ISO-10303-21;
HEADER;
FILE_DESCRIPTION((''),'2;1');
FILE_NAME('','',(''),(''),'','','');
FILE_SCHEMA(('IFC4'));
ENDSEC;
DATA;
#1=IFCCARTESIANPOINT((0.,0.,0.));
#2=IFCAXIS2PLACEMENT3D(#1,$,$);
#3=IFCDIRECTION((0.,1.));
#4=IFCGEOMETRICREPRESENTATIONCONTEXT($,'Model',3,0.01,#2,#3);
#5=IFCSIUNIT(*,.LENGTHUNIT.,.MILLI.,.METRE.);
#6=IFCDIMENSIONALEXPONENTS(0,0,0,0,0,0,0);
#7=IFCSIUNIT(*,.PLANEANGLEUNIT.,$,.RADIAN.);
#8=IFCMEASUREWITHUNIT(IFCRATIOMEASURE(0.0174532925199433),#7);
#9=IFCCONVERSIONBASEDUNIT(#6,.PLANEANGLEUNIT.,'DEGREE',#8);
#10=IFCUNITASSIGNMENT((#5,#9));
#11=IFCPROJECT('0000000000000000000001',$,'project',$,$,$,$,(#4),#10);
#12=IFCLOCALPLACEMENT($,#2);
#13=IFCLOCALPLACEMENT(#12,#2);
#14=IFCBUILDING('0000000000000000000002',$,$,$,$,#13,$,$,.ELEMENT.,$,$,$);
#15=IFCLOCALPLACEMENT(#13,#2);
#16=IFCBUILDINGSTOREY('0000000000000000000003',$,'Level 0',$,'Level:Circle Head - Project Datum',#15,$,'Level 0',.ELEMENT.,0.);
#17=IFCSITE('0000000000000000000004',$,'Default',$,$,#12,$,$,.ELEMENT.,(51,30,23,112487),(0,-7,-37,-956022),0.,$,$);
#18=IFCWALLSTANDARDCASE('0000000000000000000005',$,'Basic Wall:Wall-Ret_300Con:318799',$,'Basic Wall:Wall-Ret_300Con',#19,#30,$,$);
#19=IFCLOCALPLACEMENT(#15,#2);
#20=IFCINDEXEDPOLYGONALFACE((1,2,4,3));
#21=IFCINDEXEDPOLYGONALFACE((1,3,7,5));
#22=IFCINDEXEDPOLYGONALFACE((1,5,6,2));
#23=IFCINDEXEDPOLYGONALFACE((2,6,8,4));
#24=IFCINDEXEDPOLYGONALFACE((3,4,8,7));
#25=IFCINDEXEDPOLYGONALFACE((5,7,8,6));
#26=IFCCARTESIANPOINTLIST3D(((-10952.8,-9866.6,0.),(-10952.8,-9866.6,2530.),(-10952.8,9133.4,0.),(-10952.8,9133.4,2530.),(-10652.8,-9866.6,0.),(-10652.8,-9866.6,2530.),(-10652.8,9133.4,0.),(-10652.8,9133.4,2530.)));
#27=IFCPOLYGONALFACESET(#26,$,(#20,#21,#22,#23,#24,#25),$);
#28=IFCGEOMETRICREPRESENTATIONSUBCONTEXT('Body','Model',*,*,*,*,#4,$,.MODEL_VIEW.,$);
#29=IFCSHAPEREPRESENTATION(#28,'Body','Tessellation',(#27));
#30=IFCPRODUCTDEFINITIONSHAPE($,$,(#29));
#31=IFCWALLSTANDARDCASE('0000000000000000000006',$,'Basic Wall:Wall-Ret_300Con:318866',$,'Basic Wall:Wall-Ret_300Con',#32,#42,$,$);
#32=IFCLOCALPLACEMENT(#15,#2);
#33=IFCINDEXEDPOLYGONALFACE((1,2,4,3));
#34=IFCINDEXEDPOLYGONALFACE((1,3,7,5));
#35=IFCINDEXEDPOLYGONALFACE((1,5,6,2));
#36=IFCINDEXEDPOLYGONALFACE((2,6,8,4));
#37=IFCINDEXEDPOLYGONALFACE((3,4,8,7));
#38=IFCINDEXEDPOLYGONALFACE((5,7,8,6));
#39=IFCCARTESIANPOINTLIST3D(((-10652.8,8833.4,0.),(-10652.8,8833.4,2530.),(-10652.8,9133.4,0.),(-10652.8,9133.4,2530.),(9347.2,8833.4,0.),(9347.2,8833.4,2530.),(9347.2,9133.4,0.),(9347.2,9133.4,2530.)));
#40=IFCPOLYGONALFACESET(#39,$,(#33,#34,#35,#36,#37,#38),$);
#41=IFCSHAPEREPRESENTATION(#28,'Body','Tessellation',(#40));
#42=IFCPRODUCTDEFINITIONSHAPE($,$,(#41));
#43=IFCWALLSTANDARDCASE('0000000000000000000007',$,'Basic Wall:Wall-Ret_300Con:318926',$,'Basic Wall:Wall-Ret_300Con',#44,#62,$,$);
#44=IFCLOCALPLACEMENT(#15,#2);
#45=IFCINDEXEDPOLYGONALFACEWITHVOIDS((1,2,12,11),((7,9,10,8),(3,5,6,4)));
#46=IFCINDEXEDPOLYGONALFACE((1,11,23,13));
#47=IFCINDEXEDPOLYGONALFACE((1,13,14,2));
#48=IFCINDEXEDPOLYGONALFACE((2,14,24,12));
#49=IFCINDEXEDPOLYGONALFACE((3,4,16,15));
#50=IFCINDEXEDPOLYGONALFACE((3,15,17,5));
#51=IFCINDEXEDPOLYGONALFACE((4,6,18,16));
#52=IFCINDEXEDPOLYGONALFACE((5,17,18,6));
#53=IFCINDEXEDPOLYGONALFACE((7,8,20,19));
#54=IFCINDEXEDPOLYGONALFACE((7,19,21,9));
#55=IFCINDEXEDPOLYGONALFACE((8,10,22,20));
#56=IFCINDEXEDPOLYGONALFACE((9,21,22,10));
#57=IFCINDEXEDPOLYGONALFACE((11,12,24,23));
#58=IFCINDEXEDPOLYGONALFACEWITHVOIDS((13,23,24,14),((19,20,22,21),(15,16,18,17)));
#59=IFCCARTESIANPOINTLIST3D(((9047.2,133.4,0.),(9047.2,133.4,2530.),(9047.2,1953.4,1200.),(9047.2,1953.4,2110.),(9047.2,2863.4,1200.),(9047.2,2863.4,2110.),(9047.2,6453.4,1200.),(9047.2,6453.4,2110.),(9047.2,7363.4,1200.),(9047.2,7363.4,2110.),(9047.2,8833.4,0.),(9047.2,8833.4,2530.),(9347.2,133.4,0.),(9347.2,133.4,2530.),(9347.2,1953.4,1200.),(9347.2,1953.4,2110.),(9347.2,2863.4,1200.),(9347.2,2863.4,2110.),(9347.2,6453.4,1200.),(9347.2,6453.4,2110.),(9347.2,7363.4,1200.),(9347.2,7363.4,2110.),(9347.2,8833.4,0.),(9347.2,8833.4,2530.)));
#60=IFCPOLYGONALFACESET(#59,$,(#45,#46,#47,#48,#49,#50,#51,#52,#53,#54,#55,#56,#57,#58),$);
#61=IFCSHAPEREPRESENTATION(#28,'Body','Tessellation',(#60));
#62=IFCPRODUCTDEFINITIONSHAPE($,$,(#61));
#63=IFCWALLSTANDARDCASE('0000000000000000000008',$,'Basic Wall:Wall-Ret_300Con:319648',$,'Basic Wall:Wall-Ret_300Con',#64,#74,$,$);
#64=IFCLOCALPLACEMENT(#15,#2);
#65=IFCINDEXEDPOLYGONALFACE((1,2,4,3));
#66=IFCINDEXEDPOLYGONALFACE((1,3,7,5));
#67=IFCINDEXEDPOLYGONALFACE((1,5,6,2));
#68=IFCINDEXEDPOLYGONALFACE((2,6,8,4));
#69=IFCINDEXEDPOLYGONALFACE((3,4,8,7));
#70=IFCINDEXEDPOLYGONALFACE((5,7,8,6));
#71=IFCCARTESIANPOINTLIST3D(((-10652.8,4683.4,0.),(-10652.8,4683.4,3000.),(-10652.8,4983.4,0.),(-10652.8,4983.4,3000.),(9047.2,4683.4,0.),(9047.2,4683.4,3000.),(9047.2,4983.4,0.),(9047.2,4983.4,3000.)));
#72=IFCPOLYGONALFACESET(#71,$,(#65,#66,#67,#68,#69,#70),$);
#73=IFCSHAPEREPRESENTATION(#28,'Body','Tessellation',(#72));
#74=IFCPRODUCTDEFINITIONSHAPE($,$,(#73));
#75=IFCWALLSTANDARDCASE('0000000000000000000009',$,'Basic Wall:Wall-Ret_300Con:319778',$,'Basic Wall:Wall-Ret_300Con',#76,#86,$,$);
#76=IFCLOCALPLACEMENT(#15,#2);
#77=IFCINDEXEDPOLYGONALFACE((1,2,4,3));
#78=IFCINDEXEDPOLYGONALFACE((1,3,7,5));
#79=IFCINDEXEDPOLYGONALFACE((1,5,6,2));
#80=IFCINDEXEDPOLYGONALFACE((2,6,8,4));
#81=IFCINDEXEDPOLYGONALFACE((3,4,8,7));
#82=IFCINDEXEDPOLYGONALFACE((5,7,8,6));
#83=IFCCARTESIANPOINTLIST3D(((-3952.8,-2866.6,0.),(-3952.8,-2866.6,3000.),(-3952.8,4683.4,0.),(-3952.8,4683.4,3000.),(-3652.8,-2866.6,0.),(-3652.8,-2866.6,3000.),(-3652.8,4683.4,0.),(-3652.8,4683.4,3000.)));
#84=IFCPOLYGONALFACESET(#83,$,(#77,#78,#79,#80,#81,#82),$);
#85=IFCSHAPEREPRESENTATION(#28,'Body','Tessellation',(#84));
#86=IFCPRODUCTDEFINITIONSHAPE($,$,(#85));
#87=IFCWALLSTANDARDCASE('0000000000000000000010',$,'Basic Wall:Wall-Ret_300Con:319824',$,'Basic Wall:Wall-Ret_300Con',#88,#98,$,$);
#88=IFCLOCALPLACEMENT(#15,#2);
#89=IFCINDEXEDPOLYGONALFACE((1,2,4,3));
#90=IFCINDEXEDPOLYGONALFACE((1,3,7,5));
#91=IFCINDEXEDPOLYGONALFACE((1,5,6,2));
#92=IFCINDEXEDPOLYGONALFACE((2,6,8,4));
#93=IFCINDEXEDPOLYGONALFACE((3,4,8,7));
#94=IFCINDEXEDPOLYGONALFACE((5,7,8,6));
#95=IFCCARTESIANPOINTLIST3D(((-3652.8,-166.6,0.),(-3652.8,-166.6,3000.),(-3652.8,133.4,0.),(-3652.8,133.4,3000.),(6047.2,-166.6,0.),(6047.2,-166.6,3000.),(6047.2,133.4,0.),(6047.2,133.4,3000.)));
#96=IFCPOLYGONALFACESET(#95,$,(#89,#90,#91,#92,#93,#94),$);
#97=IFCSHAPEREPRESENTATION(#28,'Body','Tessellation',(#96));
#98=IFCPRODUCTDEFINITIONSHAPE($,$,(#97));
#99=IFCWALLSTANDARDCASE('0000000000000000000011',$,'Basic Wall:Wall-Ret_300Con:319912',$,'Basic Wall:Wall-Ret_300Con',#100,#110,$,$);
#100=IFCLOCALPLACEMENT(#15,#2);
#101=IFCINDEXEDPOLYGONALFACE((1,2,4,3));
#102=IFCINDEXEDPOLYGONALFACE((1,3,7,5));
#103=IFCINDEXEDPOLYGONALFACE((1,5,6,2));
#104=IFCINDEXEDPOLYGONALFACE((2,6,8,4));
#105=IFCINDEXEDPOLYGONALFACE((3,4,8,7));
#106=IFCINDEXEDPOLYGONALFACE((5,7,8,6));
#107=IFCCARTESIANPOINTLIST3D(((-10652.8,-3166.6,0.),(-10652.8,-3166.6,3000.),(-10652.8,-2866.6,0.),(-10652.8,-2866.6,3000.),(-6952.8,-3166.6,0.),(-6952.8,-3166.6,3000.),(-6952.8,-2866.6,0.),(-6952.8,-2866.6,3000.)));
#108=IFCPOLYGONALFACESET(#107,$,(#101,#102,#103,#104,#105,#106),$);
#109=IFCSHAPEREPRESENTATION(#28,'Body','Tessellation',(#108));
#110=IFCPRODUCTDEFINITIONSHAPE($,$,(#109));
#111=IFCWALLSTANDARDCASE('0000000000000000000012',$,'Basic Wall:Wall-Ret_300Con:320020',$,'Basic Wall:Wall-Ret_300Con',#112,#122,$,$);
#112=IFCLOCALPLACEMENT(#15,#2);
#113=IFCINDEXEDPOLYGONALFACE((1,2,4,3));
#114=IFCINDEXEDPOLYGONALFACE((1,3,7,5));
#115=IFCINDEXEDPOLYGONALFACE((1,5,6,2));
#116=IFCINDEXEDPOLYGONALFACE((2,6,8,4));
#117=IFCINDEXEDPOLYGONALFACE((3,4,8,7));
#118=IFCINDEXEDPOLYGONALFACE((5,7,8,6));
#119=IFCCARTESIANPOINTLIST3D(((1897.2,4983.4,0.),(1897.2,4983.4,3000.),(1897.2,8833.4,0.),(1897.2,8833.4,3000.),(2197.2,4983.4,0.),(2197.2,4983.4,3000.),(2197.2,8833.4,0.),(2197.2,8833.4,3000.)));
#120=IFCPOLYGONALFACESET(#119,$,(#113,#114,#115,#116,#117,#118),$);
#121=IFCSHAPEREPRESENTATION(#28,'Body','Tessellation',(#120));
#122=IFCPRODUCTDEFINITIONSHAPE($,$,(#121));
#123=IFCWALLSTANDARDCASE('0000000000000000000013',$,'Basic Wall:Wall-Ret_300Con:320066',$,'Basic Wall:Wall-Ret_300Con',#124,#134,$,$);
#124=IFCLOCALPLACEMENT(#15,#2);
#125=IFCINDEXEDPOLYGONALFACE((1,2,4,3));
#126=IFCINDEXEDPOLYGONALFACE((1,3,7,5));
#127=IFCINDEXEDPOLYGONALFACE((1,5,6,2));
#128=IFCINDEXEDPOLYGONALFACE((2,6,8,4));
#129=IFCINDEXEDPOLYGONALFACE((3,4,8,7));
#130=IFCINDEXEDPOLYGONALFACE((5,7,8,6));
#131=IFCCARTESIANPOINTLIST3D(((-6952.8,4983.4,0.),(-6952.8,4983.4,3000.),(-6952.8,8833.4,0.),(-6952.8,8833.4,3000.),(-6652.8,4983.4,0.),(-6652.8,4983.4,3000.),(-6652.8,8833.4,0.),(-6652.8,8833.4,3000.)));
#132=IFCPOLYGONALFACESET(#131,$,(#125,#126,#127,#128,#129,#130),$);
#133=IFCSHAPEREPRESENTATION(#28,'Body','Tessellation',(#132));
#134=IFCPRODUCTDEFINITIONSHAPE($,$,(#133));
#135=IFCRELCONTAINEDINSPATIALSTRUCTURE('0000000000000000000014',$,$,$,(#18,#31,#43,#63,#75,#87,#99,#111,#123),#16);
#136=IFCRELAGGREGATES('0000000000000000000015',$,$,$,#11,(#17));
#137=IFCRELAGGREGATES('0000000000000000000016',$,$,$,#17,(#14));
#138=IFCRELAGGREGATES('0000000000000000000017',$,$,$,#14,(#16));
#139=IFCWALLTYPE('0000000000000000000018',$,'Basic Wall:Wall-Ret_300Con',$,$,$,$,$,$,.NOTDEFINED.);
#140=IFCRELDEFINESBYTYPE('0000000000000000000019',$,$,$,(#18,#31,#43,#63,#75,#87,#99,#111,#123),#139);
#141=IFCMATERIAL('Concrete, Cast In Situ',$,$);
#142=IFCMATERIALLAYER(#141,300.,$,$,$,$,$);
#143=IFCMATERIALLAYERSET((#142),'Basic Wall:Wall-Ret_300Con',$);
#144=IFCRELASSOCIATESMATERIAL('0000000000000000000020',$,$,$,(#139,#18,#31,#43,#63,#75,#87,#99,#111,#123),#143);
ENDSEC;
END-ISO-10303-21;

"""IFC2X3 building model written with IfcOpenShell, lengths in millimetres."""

from ifc_helpers import new_model, entity, si_unit, converted_unit, direction, frame, frame_2d, origin, place, context, subcontext, project, spatial, polyline, rectangle, extrude, clip, bounded_halfspace, material, layer, layer_set, layer_usage, type_object, element, save


model = new_model("IFC2X3")

# Units and contexts
model_context = context("Model", 3, precision=0.01, world=origin(), true_north=direction((0.0, 1.0)))
body_context = subcontext(model_context, "Body", "Model", "MODEL_VIEW")
ifc_project = project(units=[si_unit("LENGTHUNIT", "METRE", prefix="MILLI"), converted_unit("PLANEANGLEUNIT", "DEGREE", entity("IfcRatioMeasure", 0.0174532925199433), si_unit("PLANEANGLEUNIT", "RADIAN"), dimensions=[0, 0, 0, 0, 0, 0, 0])], contexts=[model_context])

# Site, building, storey
site_placement = place(None, origin())
site = spatial("IfcSite", under=ifc_project, at=site_placement, Name="Default", CompositionType="ELEMENT", RefLatitude=(51, 30, 23, 112487), RefLongitude=(0, -7, -37, -956022), RefElevation=0.0)
building_placement = place(site_placement, origin())
building = spatial("IfcBuilding", under=site, at=building_placement, CompositionType="ELEMENT")
storey_placement = place(building_placement, origin())
storey = spatial("IfcBuildingStorey", under=building, at=storey_placement, Name="Level 0", ObjectType="Level:Circle Head - Project Datum", LongName="Level 0", CompositionType="ELEMENT", Elevation=0.0)

# Shared definitions
ifc_material_1 = material(Name="Concrete, Cast In Situ")
ifc_layer_1 = layer(ifc_material_1, 300.0)
ifc_layer_set_1 = layer_set([ifc_layer_1], Name="Basic Wall:Wall-Ret_300Con")
wall_type = type_object("IfcWallType", Name="Basic Wall:Wall-Ret_300Con", PredefinedType="NOTDEFINED", material=ifc_layer_set_1)

# Walls
ifc_layer_usage_1 = layer_usage(ifc_layer_set_1, "AXIS2", "NEGATIVE", 150.0)
wall_1_placement = place(storey_placement, frame((-10802.8, -9866.6, 0.0), z_axis=(0.0, 0.0, 1.0), x_axis=(0.0, 1.0, 0.0)))
element("IfcWallStandardCase", 1, at=wall_1_placement, inside=storey, type_object=wall_type, material=ifc_layer_usage_1, Name="Basic Wall:Wall-Ret_300Con:318799", ObjectType="Basic Wall:Wall-Ret_300Con", context=body_context, shape_type="Clipping", body=[
    clip(extrude(rectangle(XDim=19000.0, YDim=300.0, at=frame_2d((9500.0, 0.0), x_axis=(-1.0, 0.0))), origin(), (0.0, 0.0, 1.0), 2530.0), bounded_halfspace(frame((0.0, -150.0, 2530.0), z_axis=(0.0, 0.0, -1.0), x_axis=(0.0, -1.0, 0.0)), True, frame((0.0, -150.0, 2530.0)), polyline([(0.0, 0.0), (18700.0, 0.0), (19000.0, 0.0), (19000.0, 300.0), (0.0, 300.0), (0.0, 0.0)]))),
])
ifc_layer_usage_2 = layer_usage(ifc_layer_set_1, "AXIS2", "NEGATIVE", 150.0)
wall_2_placement = place(storey_placement, frame((-10652.8, 8983.4, 0.0)))
element("IfcWallStandardCase", 2, at=wall_2_placement, inside=storey, type_object=wall_type, material=ifc_layer_usage_2, Name="Basic Wall:Wall-Ret_300Con:318866", ObjectType="Basic Wall:Wall-Ret_300Con", context=body_context, shape_type="Clipping", body=[
    clip(extrude(rectangle(XDim=20000.0, YDim=300.0, at=frame_2d((10000.0, 0.0), x_axis=(-1.0, 0.0))), origin(), (0.0, 0.0, 1.0), 2530.0), bounded_halfspace(frame((0.0, -150.0, 2530.0), z_axis=(0.0, 0.0, -1.0), x_axis=(1.0, 0.0, 0.0)), True, frame((0.0, -150.0, 2530.0)), polyline([(0.0, 0.0), (19700.0, 0.0), (20000.0, 0.0), (20000.0, 300.0), (0.0, 300.0), (0.0, 0.0)]))),
])

# Wall, openings
ifc_layer_usage_3 = layer_usage(ifc_layer_set_1, "AXIS2", "NEGATIVE", 150.0)
wall_3_placement = place(storey_placement, frame((9197.2, 8833.4, 0.0), z_axis=(0.0, 0.0, 1.0), x_axis=(0.0, -1.0, 0.0)))
wall_3 = element("IfcWallStandardCase", 3, at=wall_3_placement, inside=storey, type_object=wall_type, material=ifc_layer_usage_3, Name="Basic Wall:Wall-Ret_300Con:318926", ObjectType="Basic Wall:Wall-Ret_300Con", context=body_context, shape_type="Clipping", body=[
    clip(extrude(rectangle(XDim=8700.0, YDim=300.0, at=frame_2d((4350.0, 0.0), x_axis=(-1.0, 0.0))), origin(), (0.0, 0.0, 1.0), 2530.0), bounded_halfspace(frame((0.0, -150.0, 2530.0), z_axis=(0.0, 0.0, -1.0), x_axis=(0.0, 1.0, 0.0)), True, frame((0.0, -150.0, 2530.0)), polyline([(0.0, 0.0), (8700.0, 0.0), (8700.0, 300.0), (0.0, 300.0), (0.0, 0.0)]))),
])
opening_1_placement = place(wall_3_placement, frame((5970.0, -150.0, 1200.0)))
element("IfcOpeningElement", 4, at=opening_1_placement, cuts=wall_3, ObjectType="Opening", context=body_context, shape_type="SweptSolid", body=[
    extrude(rectangle(XDim=910.0, YDim=910.0, at=frame_2d((455.0, 455.0), x_axis=(-1.0, 0.0))), frame((0.0, 0.0, 0.0), z_axis=(0.0, 1.0, 0.0), x_axis=(0.0, 0.0, 1.0)), (0.0, 0.0, 1.0), 300.0),
])
opening_2_placement = place(wall_3_placement, frame((1470.0, -150.0, 1200.0)))
element("IfcOpeningElement", 5, at=opening_2_placement, cuts=wall_3, ObjectType="Opening", context=body_context, shape_type="SweptSolid", body=[
    extrude(rectangle(XDim=910.0, YDim=910.0, at=frame_2d((455.0, 455.0), x_axis=(-1.0, 0.0))), frame((0.0, 0.0, 0.0), z_axis=(0.0, 1.0, 0.0), x_axis=(0.0, 0.0, 1.0)), (0.0, 0.0, 1.0), 300.0),
])

# Walls
ifc_layer_usage_4 = layer_usage(ifc_layer_set_1, "AXIS2", "NEGATIVE", 150.0)
wall_4_placement = place(storey_placement, frame((-10652.8, 4833.4, 0.0)))
element("IfcWallStandardCase", 6, at=wall_4_placement, inside=storey, type_object=wall_type, material=ifc_layer_usage_4, Name="Basic Wall:Wall-Ret_300Con:319648", ObjectType="Basic Wall:Wall-Ret_300Con", context=body_context, shape_type="SweptSolid", body=[
    extrude(rectangle(XDim=19700.0, YDim=300.0, at=frame_2d((9850.0, 0.0), x_axis=(-1.0, 0.0))), origin(), (0.0, 0.0, 1.0), 3000.0),
])
ifc_layer_usage_5 = layer_usage(ifc_layer_set_1, "AXIS2", "NEGATIVE", 150.0)
wall_5_placement = place(storey_placement, frame((-3802.8, 4683.4, 0.0), z_axis=(0.0, 0.0, 1.0), x_axis=(0.0, -1.0, 0.0)))
element("IfcWallStandardCase", 7, at=wall_5_placement, inside=storey, type_object=wall_type, material=ifc_layer_usage_5, Name="Basic Wall:Wall-Ret_300Con:319778", ObjectType="Basic Wall:Wall-Ret_300Con", context=body_context, shape_type="SweptSolid", body=[
    extrude(rectangle(XDim=7550.0, YDim=300.0, at=frame_2d((3775.0, 0.0), x_axis=(-1.0, 0.0))), origin(), (0.0, 0.0, 1.0), 3000.0),
])
ifc_layer_usage_6 = layer_usage(ifc_layer_set_1, "AXIS2", "NEGATIVE", 150.0)
wall_6_placement = place(storey_placement, frame((6047.2, -16.6, 0.0), z_axis=(0.0, 0.0, 1.0), x_axis=(-1.0, 0.0, 0.0)))
element("IfcWallStandardCase", 8, at=wall_6_placement, inside=storey, type_object=wall_type, material=ifc_layer_usage_6, Name="Basic Wall:Wall-Ret_300Con:319824", ObjectType="Basic Wall:Wall-Ret_300Con", context=body_context, shape_type="SweptSolid", body=[
    extrude(rectangle(XDim=9700.0, YDim=300.0, at=frame_2d((4850.0, 0.0), x_axis=(-1.0, 0.0))), origin(), (0.0, 0.0, 1.0), 3000.0),
])
ifc_layer_usage_7 = layer_usage(ifc_layer_set_1, "AXIS2", "NEGATIVE", 150.0)
wall_7_placement = place(storey_placement, frame((-6952.8, -3016.6, 0.0), z_axis=(0.0, 0.0, 1.0), x_axis=(-1.0, 0.0, 0.0)))
element("IfcWallStandardCase", 9, at=wall_7_placement, inside=storey, type_object=wall_type, material=ifc_layer_usage_7, Name="Basic Wall:Wall-Ret_300Con:319912", ObjectType="Basic Wall:Wall-Ret_300Con", context=body_context, shape_type="SweptSolid", body=[
    extrude(rectangle(XDim=3700.0, YDim=300.0, at=frame_2d((1850.0, 0.0), x_axis=(-1.0, 0.0))), origin(), (0.0, 0.0, 1.0), 3000.0),
])
ifc_layer_usage_8 = layer_usage(ifc_layer_set_1, "AXIS2", "NEGATIVE", 150.0)
wall_8_placement = place(storey_placement, frame((2047.2, 4983.4, 0.0), z_axis=(0.0, 0.0, 1.0), x_axis=(0.0, 1.0, 0.0)))
element("IfcWallStandardCase", 10, at=wall_8_placement, inside=storey, type_object=wall_type, material=ifc_layer_usage_8, Name="Basic Wall:Wall-Ret_300Con:320020", ObjectType="Basic Wall:Wall-Ret_300Con", context=body_context, shape_type="SweptSolid", body=[
    extrude(rectangle(XDim=3850.0, YDim=300.0, at=frame_2d((1925.0, 0.0), x_axis=(-1.0, 0.0))), origin(), (0.0, 0.0, 1.0), 3000.0),
])
ifc_layer_usage_9 = layer_usage(ifc_layer_set_1, "AXIS2", "NEGATIVE", 150.0)
wall_9_placement = place(storey_placement, frame((-6802.8, 4983.4, 0.0), z_axis=(0.0, 0.0, 1.0), x_axis=(0.0, 1.0, 0.0)))
element("IfcWallStandardCase", 11, at=wall_9_placement, inside=storey, type_object=wall_type, material=ifc_layer_usage_9, Name="Basic Wall:Wall-Ret_300Con:320066", ObjectType="Basic Wall:Wall-Ret_300Con", context=body_context, shape_type="SweptSolid", body=[
    extrude(rectangle(XDim=3850.0, YDim=300.0, at=frame_2d((1925.0, 0.0), x_axis=(-1.0, 0.0))), origin(), (0.0, 0.0, 1.0), 3000.0),
])

save(model, "model.ifc")
